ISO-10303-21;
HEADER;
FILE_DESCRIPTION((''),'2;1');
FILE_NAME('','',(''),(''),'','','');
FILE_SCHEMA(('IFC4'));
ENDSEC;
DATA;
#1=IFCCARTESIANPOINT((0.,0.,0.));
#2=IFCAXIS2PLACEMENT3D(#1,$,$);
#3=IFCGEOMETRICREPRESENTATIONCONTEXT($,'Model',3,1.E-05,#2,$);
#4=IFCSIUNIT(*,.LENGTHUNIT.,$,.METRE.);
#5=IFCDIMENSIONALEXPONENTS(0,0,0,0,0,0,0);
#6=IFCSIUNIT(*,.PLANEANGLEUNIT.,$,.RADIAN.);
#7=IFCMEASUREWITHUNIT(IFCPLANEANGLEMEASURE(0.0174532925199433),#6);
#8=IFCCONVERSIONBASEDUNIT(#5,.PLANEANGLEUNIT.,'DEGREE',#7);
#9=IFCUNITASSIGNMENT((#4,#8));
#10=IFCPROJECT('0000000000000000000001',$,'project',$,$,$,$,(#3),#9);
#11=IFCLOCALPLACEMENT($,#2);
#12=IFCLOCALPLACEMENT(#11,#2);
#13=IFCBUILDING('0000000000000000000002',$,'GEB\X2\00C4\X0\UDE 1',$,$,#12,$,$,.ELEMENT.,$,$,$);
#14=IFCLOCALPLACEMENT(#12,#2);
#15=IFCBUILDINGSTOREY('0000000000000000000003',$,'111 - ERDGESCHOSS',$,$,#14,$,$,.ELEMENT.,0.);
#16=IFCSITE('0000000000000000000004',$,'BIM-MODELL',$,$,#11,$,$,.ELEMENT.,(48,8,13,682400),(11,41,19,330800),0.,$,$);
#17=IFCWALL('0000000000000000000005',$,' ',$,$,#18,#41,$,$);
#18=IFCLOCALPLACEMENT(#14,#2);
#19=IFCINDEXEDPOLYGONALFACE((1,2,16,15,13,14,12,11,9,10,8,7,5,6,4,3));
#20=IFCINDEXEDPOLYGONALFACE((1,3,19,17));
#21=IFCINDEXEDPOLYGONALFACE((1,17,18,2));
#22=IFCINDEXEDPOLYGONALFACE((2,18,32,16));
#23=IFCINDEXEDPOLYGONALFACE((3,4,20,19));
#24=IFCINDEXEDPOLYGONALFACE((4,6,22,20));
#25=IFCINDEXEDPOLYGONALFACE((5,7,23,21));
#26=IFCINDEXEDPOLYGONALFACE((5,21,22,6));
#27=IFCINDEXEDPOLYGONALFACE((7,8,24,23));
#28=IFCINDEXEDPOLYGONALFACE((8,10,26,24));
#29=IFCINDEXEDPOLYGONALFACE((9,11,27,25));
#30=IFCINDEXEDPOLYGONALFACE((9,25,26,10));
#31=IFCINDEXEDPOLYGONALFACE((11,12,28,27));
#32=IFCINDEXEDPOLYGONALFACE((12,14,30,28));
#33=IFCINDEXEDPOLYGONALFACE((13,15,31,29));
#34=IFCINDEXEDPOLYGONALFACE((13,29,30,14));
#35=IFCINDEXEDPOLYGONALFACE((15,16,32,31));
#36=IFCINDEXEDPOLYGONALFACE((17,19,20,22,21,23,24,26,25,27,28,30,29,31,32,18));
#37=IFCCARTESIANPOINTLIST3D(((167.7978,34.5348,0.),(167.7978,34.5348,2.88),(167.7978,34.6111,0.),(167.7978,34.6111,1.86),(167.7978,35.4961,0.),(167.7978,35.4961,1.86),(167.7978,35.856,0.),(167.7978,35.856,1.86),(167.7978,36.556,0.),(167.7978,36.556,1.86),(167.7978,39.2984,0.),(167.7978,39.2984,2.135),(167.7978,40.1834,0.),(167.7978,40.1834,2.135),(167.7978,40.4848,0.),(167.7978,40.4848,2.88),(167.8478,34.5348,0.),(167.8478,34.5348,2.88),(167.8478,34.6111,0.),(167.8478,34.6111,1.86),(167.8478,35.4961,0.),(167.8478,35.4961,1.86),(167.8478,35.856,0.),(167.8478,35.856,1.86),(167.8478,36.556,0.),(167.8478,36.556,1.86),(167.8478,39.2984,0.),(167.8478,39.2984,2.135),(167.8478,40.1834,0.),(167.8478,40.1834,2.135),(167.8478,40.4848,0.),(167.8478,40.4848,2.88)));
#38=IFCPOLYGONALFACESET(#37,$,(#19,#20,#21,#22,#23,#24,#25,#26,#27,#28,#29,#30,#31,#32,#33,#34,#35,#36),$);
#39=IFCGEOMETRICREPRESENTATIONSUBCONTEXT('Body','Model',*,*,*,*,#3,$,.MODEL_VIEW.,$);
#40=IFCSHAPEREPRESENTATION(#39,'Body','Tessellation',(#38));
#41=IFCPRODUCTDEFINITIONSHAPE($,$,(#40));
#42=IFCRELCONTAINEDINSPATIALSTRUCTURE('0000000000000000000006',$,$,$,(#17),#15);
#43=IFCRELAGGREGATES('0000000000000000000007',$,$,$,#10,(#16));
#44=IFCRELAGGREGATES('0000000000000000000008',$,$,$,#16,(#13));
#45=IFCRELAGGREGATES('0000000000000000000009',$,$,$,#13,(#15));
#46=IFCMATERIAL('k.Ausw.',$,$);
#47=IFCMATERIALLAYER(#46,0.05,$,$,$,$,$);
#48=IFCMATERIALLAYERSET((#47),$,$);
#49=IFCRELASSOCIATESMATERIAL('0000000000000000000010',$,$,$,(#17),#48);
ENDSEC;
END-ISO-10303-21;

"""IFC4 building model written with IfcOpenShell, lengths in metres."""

from ifc_helpers import new_model, entity, si_unit, converted_unit, frame, frame_2d, origin, origin_with_axes, place, context, subcontext, project, spatial, polyline, rectangle, outline, extrude, material, layer, layer_set, layer_usage, element, save


model = new_model("IFC4")

# Units and contexts
model_context = context("Model", 3, precision=1e-05, world=origin())
body_context = subcontext(model_context, "Body", "Model", "MODEL_VIEW")
ifc_project = project(units=[si_unit("LENGTHUNIT", "METRE"), converted_unit("PLANEANGLEUNIT", "DEGREE", entity("IfcPlaneAngleMeasure", 0.0174532925199433), si_unit("PLANEANGLEUNIT", "RADIAN"), dimensions=[0, 0, 0, 0, 0, 0, 0])], contexts=[model_context])

# Site, building, storey
site_placement = place(None, origin())
site = spatial("IfcSite", under=ifc_project, at=site_placement, Name="BIM-MODELL", CompositionType="ELEMENT", RefLatitude=(48, 8, 13, 682400), RefLongitude=(11, 41, 19, 330800), RefElevation=0.0)
building_placement = place(site_placement, origin())
building = spatial("IfcBuilding", under=site, at=building_placement, Name="GEBÄUDE 1", CompositionType="ELEMENT")
storey_placement = place(building_placement, origin())
storey = spatial("IfcBuildingStorey", under=building, at=storey_placement, Name="111 - ERDGESCHOSS", CompositionType="ELEMENT", Elevation=0.0)

# Wall, openings
ifc_material_1 = material(Name="k.Ausw.")
ifc_layer_1 = layer(ifc_material_1, 0.05)
ifc_layer_set_1 = layer_set([ifc_layer_1])
ifc_layer_usage_1 = layer_usage(ifc_layer_set_1, "AXIS2", "POSITIVE", 0.0)
wall_1_placement = place(storey_placement, frame((167.8478, 34.5348, 0.0), z_axis=(0.0, 0.0, 1.0), x_axis=(0.0, 1.0, 0.0)))
wall_1 = element("IfcWall", 1, at=wall_1_placement, inside=storey, material=ifc_layer_usage_1, Name=" ", context=body_context, shape_type="SweptSolid", body=[
    extrude(rectangle(XDim=5.95, YDim=0.05, at=frame_2d((2.975, 0.025), x_axis=(1.0, 0.0))), origin_with_axes(), (0.0, 0.0, 1.0), 2.88),
])
opening_1_placement = place(wall_1_placement, frame((1.3213, 0.0, -0.15), z_axis=(0.0, 1.0, 0.0), x_axis=(0.0, 0.0, 1.0)))
element("IfcOpeningElement", 2, at=opening_1_placement, cuts=wall_1, ObjectType="Opening", context=body_context, shape_type="SweptSolid", body=[
    extrude(outline(polyline([(0.0, 0.7), (2.01, 0.7), (2.01, 0.0), (0.0, 0.0), (0.0, 0.7)])), origin_with_axes(), (0.0, 0.0, 1.0), 0.05),
])
opening_2_placement = place(wall_1_placement, frame((0.9613, 0.05, -0.15), z_axis=(0.0, -1.0, 0.0), x_axis=(0.0, 0.0, 1.0)))
element("IfcOpeningElement", 3, at=opening_2_placement, cuts=wall_1, ObjectType="Opening", context=body_context, shape_type="SweptSolid", body=[
    extrude(outline(polyline([(0.0, 0.885), (2.01, 0.885), (2.01, 0.0), (0.0, 0.0), (0.0, 0.885)])), origin_with_axes(), (0.0, 0.0, 1.0), 0.05),
])
opening_3_placement = place(wall_1_placement, frame((4.7636, 0.0, 0.0), z_axis=(0.0, 1.0, 0.0), x_axis=(0.0, 0.0, 1.0)))
element("IfcOpeningElement", 4, at=opening_3_placement, cuts=wall_1, ObjectType="Opening", context=body_context, shape_type="SweptSolid", body=[
    extrude(outline(polyline([(0.0, 0.885), (2.135, 0.885), (2.135, 0.0), (0.0, 0.0), (0.0, 0.885)])), origin_with_axes(), (0.0, 0.0, 1.0), 0.05),
])

save(model, "model.ifc")
